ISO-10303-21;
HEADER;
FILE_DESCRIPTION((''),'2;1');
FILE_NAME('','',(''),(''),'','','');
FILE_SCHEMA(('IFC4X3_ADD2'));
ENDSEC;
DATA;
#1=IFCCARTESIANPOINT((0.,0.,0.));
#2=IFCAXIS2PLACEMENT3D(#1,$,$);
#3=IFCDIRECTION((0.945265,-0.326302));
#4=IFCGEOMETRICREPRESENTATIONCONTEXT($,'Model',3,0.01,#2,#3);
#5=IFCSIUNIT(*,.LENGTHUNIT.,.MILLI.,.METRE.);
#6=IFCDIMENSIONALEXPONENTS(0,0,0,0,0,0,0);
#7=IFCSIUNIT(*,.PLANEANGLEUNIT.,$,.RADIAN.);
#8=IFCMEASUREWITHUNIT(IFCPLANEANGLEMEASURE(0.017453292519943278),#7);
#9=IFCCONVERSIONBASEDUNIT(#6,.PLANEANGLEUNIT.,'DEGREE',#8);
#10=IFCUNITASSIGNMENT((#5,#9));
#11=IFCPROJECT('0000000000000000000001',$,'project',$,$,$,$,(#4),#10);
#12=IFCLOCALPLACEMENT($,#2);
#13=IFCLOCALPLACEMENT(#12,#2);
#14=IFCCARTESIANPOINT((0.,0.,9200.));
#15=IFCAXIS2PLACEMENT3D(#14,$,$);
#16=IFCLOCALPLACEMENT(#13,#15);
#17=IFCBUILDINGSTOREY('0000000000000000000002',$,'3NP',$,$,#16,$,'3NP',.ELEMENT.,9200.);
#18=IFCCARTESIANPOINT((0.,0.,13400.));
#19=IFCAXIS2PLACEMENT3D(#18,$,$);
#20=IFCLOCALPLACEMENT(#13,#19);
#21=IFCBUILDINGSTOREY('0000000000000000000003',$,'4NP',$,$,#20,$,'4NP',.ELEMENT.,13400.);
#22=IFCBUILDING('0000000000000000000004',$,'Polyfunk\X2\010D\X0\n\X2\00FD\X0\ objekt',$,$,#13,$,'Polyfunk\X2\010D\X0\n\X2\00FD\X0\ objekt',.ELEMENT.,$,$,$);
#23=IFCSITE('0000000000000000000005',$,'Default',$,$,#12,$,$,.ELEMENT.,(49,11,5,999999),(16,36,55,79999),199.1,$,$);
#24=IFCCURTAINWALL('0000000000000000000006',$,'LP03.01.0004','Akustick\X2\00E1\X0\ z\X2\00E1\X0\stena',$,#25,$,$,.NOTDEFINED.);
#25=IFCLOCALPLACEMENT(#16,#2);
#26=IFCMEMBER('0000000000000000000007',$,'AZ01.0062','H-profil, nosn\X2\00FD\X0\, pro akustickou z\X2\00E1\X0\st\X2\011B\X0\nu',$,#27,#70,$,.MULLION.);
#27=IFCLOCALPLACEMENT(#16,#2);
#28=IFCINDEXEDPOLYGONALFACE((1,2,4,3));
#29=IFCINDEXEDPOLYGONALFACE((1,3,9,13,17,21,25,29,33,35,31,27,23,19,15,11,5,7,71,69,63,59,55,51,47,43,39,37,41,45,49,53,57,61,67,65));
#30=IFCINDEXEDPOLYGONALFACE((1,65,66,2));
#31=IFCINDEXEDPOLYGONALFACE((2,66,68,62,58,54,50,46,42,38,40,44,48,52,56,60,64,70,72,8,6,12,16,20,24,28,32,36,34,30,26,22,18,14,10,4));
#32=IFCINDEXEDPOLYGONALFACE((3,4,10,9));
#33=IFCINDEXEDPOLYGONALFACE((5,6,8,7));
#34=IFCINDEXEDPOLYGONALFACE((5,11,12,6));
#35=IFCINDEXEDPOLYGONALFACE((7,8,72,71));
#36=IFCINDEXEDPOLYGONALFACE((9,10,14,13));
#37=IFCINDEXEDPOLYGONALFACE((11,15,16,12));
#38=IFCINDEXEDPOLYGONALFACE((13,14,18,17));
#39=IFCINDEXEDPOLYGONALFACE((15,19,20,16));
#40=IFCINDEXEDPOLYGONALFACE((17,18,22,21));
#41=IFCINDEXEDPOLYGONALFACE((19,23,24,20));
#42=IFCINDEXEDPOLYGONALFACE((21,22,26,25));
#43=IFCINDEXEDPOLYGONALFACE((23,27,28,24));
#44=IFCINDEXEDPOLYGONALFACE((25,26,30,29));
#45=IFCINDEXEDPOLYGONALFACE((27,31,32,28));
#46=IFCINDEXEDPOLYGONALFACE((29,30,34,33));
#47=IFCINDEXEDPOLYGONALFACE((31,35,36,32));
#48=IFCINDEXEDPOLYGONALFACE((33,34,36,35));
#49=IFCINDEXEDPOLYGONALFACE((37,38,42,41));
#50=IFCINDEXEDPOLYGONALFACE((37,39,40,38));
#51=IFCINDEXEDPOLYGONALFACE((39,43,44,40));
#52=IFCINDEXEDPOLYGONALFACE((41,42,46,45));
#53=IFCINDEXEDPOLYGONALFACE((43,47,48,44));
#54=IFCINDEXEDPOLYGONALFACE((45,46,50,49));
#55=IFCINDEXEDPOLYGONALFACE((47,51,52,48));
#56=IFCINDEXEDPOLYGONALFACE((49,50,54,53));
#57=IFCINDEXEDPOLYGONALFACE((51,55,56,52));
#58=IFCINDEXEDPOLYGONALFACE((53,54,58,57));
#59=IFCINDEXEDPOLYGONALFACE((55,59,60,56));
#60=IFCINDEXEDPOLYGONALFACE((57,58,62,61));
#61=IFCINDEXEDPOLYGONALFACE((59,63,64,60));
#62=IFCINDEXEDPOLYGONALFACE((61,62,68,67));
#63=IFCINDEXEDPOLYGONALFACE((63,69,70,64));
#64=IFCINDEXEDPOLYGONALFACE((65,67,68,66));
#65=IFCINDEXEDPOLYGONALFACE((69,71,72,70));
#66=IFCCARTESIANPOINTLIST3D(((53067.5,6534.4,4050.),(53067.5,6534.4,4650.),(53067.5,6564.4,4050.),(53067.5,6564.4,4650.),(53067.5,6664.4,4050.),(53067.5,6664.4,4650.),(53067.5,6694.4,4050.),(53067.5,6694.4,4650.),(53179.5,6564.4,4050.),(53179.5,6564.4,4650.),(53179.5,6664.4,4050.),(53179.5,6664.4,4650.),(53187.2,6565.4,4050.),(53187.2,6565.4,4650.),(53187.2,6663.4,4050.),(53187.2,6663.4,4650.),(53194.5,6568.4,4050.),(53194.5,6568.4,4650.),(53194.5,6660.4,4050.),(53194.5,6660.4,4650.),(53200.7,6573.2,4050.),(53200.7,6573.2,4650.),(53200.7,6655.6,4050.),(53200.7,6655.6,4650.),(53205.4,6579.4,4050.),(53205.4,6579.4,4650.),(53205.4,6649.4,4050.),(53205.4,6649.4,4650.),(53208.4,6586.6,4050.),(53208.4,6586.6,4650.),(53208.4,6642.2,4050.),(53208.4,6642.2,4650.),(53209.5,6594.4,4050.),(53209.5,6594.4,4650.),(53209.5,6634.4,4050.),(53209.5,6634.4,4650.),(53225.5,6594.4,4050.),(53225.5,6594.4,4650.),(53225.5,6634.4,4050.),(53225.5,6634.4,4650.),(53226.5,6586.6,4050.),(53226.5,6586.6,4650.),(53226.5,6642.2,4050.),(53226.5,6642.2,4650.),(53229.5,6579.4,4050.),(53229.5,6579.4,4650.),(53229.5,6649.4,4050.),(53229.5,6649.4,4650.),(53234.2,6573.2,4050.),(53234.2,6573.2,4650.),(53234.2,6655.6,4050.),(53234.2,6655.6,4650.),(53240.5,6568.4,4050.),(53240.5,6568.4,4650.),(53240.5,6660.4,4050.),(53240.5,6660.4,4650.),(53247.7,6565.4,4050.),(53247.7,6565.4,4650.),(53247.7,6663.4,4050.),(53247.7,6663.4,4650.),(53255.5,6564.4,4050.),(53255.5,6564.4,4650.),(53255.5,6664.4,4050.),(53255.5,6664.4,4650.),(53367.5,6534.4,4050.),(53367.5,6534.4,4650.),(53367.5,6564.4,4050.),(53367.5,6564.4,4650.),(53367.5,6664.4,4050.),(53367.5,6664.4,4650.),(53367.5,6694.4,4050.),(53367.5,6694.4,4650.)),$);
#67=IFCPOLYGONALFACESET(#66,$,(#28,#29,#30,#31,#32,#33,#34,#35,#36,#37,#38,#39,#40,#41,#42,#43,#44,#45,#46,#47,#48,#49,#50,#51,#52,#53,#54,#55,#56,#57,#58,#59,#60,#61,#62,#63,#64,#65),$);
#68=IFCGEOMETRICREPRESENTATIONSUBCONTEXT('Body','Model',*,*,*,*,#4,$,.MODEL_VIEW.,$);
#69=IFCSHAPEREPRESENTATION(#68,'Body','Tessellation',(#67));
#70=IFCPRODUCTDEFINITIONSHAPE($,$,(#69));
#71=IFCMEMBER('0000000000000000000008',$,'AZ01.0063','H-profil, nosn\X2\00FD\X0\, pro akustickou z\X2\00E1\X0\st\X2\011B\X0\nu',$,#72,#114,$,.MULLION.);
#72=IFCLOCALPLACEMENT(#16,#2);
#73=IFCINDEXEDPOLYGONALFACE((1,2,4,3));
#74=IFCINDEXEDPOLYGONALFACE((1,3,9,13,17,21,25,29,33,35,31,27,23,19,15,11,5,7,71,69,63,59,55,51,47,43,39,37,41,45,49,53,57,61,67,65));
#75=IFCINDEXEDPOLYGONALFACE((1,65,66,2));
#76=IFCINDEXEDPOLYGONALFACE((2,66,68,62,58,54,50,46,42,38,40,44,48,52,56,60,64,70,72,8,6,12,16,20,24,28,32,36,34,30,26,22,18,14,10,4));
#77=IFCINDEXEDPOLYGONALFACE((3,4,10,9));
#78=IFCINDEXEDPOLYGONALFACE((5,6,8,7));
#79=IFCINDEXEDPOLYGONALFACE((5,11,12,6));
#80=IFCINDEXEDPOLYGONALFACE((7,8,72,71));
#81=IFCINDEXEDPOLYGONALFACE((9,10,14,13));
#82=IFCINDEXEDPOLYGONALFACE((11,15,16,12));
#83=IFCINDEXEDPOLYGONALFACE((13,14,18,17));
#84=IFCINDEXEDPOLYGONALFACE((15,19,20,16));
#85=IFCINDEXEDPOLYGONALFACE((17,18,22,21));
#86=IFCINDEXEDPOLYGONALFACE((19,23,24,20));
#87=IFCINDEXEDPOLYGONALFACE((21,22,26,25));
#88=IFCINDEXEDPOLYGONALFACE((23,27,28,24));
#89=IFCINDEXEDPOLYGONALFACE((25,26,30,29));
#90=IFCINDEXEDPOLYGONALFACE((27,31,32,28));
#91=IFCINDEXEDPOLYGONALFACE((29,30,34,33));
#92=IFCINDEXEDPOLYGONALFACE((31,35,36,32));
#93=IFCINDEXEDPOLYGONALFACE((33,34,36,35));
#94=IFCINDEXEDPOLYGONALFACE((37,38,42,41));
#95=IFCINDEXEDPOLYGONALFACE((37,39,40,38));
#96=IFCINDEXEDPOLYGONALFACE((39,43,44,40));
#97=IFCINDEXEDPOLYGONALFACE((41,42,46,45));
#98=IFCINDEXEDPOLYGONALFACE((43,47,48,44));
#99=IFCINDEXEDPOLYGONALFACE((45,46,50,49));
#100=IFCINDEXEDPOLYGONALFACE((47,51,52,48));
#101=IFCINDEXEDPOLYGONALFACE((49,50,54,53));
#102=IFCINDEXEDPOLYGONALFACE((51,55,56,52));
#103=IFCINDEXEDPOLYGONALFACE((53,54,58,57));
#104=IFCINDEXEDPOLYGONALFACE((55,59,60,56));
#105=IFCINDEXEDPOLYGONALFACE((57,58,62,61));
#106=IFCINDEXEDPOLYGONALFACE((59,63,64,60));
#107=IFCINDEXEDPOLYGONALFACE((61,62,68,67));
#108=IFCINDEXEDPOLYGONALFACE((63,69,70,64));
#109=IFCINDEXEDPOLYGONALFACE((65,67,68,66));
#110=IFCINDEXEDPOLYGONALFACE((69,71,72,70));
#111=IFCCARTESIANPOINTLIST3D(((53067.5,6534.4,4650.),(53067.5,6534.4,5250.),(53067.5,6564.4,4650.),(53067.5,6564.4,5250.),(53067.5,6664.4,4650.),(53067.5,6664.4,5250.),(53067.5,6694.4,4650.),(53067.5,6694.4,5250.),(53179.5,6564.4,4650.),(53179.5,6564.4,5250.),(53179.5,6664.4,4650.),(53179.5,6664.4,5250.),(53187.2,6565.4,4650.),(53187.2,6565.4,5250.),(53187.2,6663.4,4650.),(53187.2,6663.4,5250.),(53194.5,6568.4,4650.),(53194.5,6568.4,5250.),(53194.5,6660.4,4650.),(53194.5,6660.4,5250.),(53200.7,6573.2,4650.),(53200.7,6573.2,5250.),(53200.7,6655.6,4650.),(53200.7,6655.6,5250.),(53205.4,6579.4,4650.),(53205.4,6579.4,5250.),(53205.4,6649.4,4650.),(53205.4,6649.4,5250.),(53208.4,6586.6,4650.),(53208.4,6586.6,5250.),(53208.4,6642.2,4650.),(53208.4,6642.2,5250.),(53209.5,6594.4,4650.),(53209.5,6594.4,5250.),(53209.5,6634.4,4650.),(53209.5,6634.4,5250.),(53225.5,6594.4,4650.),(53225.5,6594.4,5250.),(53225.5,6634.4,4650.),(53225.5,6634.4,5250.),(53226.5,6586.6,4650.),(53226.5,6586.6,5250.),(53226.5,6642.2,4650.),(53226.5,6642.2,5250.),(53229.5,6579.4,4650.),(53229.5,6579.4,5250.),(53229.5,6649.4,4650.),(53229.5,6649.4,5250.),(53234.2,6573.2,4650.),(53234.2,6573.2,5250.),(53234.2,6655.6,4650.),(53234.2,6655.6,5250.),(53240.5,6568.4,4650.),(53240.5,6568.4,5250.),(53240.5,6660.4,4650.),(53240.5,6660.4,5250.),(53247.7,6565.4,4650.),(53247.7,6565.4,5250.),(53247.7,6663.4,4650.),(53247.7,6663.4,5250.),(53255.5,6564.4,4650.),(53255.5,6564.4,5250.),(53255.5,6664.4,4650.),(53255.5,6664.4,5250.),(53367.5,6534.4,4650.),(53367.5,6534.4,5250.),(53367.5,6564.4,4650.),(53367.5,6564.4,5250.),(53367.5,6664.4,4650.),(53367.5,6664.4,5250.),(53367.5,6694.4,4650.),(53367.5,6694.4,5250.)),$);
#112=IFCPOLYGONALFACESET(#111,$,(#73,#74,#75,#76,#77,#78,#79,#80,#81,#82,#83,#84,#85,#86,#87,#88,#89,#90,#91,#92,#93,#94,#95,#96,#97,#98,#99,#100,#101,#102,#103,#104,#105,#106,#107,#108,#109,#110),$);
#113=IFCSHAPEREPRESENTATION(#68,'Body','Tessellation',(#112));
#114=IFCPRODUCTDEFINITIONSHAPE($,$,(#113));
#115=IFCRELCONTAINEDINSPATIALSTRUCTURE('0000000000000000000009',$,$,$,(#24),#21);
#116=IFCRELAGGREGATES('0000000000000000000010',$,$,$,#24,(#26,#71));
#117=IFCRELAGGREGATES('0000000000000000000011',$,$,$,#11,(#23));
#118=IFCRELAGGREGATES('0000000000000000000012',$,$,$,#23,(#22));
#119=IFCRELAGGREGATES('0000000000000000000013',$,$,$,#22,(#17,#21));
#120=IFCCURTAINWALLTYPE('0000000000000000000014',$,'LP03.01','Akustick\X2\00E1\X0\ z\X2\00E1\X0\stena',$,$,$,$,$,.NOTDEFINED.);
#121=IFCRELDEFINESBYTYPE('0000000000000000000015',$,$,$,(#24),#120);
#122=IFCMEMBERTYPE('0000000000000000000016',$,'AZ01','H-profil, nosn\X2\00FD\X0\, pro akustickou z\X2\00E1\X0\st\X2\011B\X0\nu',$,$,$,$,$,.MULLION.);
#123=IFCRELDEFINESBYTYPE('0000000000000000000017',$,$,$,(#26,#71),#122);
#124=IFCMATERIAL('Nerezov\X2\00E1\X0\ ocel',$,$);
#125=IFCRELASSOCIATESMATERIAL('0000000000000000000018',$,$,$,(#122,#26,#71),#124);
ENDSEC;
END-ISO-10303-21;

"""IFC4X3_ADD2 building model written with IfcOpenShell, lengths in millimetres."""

from ifc_helpers import new_model, entity, si_unit, converted_unit, direction, frame, frame_2d, origin, place, context, subcontext, project, spatial, polyline, circle_curve, parameter, trimmed, segment, composite_curve, outline, extrude, source, transform, mapped, material, material_profile, profile_set, profile_usage, type_object, element, aggregate, save


model = new_model("IFC4X3_ADD2")

# Units and contexts
model_context = context("Model", 3, precision=0.01, world=origin(), true_north=direction((0.945265, -0.326302)))
body_context = subcontext(model_context, "Body", "Model", "MODEL_VIEW")
ifc_project = project(units=[si_unit("LENGTHUNIT", "METRE", prefix="MILLI"), converted_unit("PLANEANGLEUNIT", "DEGREE", entity("IfcPlaneAngleMeasure", 0.017453292519943278), si_unit("PLANEANGLEUNIT", "RADIAN"), dimensions=[0, 0, 0, 0, 0, 0, 0])], contexts=[model_context])

# Site, building, storey
site_placement = place(None, origin())
site = spatial("IfcSite", under=ifc_project, at=site_placement, Name="Default", CompositionType="ELEMENT", RefLatitude=(49, 11, 5, 999999), RefLongitude=(16, 36, 55, 79999), RefElevation=199.1)
building_placement = place(site_placement, origin())
building = spatial("IfcBuilding", under=site, at=building_placement, Name="Polyfunkčný objekt", LongName="Polyfunkčný objekt", CompositionType="ELEMENT")
storey_1_placement = place(building_placement, frame((0.0, 0.0, 9200.0)))
storey_1 = spatial("IfcBuildingStorey", under=building, at=storey_1_placement, Name="3NP", LongName="3NP", CompositionType="ELEMENT", Elevation=9200.0)

# Shared definitions
storey_2_placement = place(building_placement, frame((0.0, 0.0, 13400.0)))
storey_2 = spatial("IfcBuildingStorey", under=building, at=storey_2_placement, Name="4NP", LongName="4NP", CompositionType="ELEMENT", Elevation=13400.0)

# Curtain wall, members
curtain_wall_type_1 = type_object("IfcCurtainWallType", Name="LP03.01", Description="Akustická zástena", PredefinedType="NOTDEFINED")
curtain_wall_1_placement = place(storey_2_placement, frame((0.0, 0.0, -13400.0)))
curtain_wall_1 = element("IfcCurtainWall", 1, at=curtain_wall_1_placement, inside=storey_2, type_object=curtain_wall_type_1, Name="LP03.01.0004", Description="Akustická zástena", PredefinedType="NOTDEFINED")
ifc_material_1 = material(Name="Nerezová ocel")
ifc_material_profile_1 = material_profile(ifc_material_1, outline(composite_curve([segment(polyline([(50.0, -150.0), (80.0, -150.0)]), True, "CONTINUOUS"), segment(polyline([(80.0, -150.0), (80.0, 150.0)]), True, "CONTINUOUS"), segment(polyline([(80.0, 150.0), (50.0, 150.0)]), True, "CONTINUOUS"), segment(polyline([(50.0, 150.0), (50.0, 38.0)]), True, "CONTINUOUS"), segment(trimmed(circle_curve(frame_2d((20.0, 38.0), x_axis=(0.0, 1.0)), 30.0), [parameter(180.0)], [parameter(270.0)], True, "PARAMETER"), False, "CONTINUOUS"), segment(polyline([(20.0, 8.0), (-20.0, 8.0)]), True, "CONTINUOUS"), segment(trimmed(circle_curve(frame_2d((-20.0, 38.0), x_axis=(0.0, 1.0)), 30.0), [parameter(90.0)], [parameter(180.0)], True, "PARAMETER"), False, "CONTINUOUS"), segment(polyline([(-50.0, 38.0), (-50.0, 150.0)]), True, "CONTINUOUS"), segment(polyline([(-50.0, 150.0), (-80.0, 150.0)]), True, "CONTINUOUS"), segment(polyline([(-80.0, 150.0), (-80.0, -150.0)]), True, "CONTINUOUS"), segment(polyline([(-80.0, -150.0), (-50.0, -150.0)]), True, "CONTINUOUS"), segment(polyline([(-50.0, -150.0), (-50.0, -38.0)]), True, "CONTINUOUS"), segment(trimmed(circle_curve(frame_2d((-20.0, -38.0), x_axis=(0.0, 1.0)), 30.0), [parameter(0.0)], [parameter(90.0)], True, "PARAMETER"), False, "CONTINUOUS"), segment(polyline([(-20.0, -8.0), (20.0, -8.0)]), True, "CONTINUOUS"), segment(trimmed(circle_curve(frame_2d((20.0, -38.0), x_axis=(0.0, 1.0)), 30.0), [parameter(270.0)], [parameter(0.0)], True, "PARAMETER"), False, "CONTINUOUS"), segment(polyline([(50.0, -38.0), (50.0, -150.0)]), True, "CONTINUOUS")], self_intersect=False)), Name="Profil zástena")
ifc_profile_set_1 = profile_set([ifc_material_profile_1], Name="Profil zástena")
ifc_profile_usage_1 = profile_usage(ifc_profile_set_1)
member_type_1 = type_object("IfcMemberType", Name="AZ01", Description="H-profil, nosný, pro akustickou zástěnu", PredefinedType="MULLION", material=ifc_profile_set_1)
shared_shape_1 = source(origin(), body_context, "Body", "SweptSolid", [
    extrude(outline(composite_curve([segment(polyline([(50.0, -150.0), (80.0, -150.0)]), True, "CONTINUOUS"), segment(polyline([(80.0, -150.0), (80.0, 150.0)]), True, "CONTINUOUS"), segment(polyline([(80.0, 150.0), (50.0, 150.0)]), True, "CONTINUOUS"), segment(polyline([(50.0, 150.0), (50.0, 38.0)]), True, "CONTINUOUS"), segment(trimmed(circle_curve(frame_2d((20.0, 38.0), x_axis=(0.0, 1.0)), 30.0), [parameter(180.0)], [parameter(270.0)], True, "PARAMETER"), False, "CONTINUOUS"), segment(polyline([(20.0, 8.0), (-20.0, 8.0)]), True, "CONTINUOUS"), segment(trimmed(circle_curve(frame_2d((-20.0, 38.0), x_axis=(0.0, 1.0)), 30.0), [parameter(90.0)], [parameter(180.0)], True, "PARAMETER"), False, "CONTINUOUS"), segment(polyline([(-50.0, 38.0), (-50.0, 150.0)]), True, "CONTINUOUS"), segment(polyline([(-50.0, 150.0), (-80.0, 150.0)]), True, "CONTINUOUS"), segment(polyline([(-80.0, 150.0), (-80.0, -150.0)]), True, "CONTINUOUS"), segment(polyline([(-80.0, -150.0), (-50.0, -150.0)]), True, "CONTINUOUS"), segment(polyline([(-50.0, -150.0), (-50.0, -38.0)]), True, "CONTINUOUS"), segment(trimmed(circle_curve(frame_2d((-20.0, -38.0), x_axis=(0.0, 1.0)), 30.0), [parameter(0.0)], [parameter(90.0)], True, "PARAMETER"), False, "CONTINUOUS"), segment(polyline([(-20.0, -8.0), (20.0, -8.0)]), True, "CONTINUOUS"), segment(trimmed(circle_curve(frame_2d((20.0, -38.0), x_axis=(0.0, 1.0)), 30.0), [parameter(270.0)], [parameter(0.0)], True, "PARAMETER"), False, "CONTINUOUS"), segment(polyline([(50.0, -38.0), (50.0, -150.0)]), True, "CONTINUOUS")], self_intersect=False)), frame((0.0, 0.0, -600.0), z_axis=(0.0, 0.0, 1.0), x_axis=(0.0, -1.0, 0.0)), (0.0, 0.0, 1.0), 600.0),
])
member_1_placement = place(curtain_wall_1_placement, frame((53217.5, 6614.4, 13250.0), z_axis=(0.0, 0.0, -1.0), x_axis=(1.0, 0.0, 0.0)))
member_1 = element("IfcMember", 2, at=member_1_placement, type_object=member_type_1, material=ifc_profile_usage_1, Name="AZ01.0062", Description="H-profil, nosný, pro akustickou zástěnu", PredefinedType="MULLION", context=body_context, shape_type="MappedRepresentation", body=[
    mapped(shared_shape_1, transform((0.0, 0.0, 0.0), scale=1.0)),
])
shared_shape_2 = source(origin(), body_context, "Body", "SweptSolid", [
    extrude(outline(composite_curve([segment(polyline([(50.0, -150.0), (80.0, -150.0)]), True, "CONTINUOUS"), segment(polyline([(80.0, -150.0), (80.0, 150.0)]), True, "CONTINUOUS"), segment(polyline([(80.0, 150.0), (50.0, 150.0)]), True, "CONTINUOUS"), segment(polyline([(50.0, 150.0), (50.0, 38.0)]), True, "CONTINUOUS"), segment(trimmed(circle_curve(frame_2d((20.0, 38.0), x_axis=(0.0, 1.0)), 30.0), [parameter(180.0)], [parameter(270.0)], True, "PARAMETER"), False, "CONTINUOUS"), segment(polyline([(20.0, 8.0), (-20.0, 8.0)]), True, "CONTINUOUS"), segment(trimmed(circle_curve(frame_2d((-20.0, 38.0), x_axis=(0.0, 1.0)), 30.0), [parameter(90.0)], [parameter(180.0)], True, "PARAMETER"), False, "CONTINUOUS"), segment(polyline([(-50.0, 38.0), (-50.0, 150.0)]), True, "CONTINUOUS"), segment(polyline([(-50.0, 150.0), (-80.0, 150.0)]), True, "CONTINUOUS"), segment(polyline([(-80.0, 150.0), (-80.0, -150.0)]), True, "CONTINUOUS"), segment(polyline([(-80.0, -150.0), (-50.0, -150.0)]), True, "CONTINUOUS"), segment(polyline([(-50.0, -150.0), (-50.0, -38.0)]), True, "CONTINUOUS"), segment(trimmed(circle_curve(frame_2d((-20.0, -38.0), x_axis=(0.0, 1.0)), 30.0), [parameter(0.0)], [parameter(90.0)], True, "PARAMETER"), False, "CONTINUOUS"), segment(polyline([(-20.0, -8.0), (20.0, -8.0)]), True, "CONTINUOUS"), segment(trimmed(circle_curve(frame_2d((20.0, -38.0), x_axis=(0.0, 1.0)), 30.0), [parameter(270.0)], [parameter(0.0)], True, "PARAMETER"), False, "CONTINUOUS"), segment(polyline([(50.0, -38.0), (50.0, -150.0)]), True, "CONTINUOUS")], self_intersect=False)), frame((0.0, 0.0, -600.0), z_axis=(0.0, 0.0, 1.0), x_axis=(0.0, -1.0, 0.0)), (0.0, 0.0, 1.0), 600.0),
])
member_2_placement = place(curtain_wall_1_placement, frame((53217.5, 6614.4, 13850.0), z_axis=(0.0, 0.0, -1.0), x_axis=(1.0, 0.0, 0.0)))
member_2 = element("IfcMember", 3, at=member_2_placement, type_object=member_type_1, material=ifc_profile_usage_1, Name="AZ01.0063", Description="H-profil, nosný, pro akustickou zástěnu", PredefinedType="MULLION", context=body_context, shape_type="MappedRepresentation", body=[
    mapped(shared_shape_2, transform((0.0, 0.0, 0.0), scale=1.0)),
])
aggregate(curtain_wall_1, [member_1, member_2])

save(model, "model.ifc")
